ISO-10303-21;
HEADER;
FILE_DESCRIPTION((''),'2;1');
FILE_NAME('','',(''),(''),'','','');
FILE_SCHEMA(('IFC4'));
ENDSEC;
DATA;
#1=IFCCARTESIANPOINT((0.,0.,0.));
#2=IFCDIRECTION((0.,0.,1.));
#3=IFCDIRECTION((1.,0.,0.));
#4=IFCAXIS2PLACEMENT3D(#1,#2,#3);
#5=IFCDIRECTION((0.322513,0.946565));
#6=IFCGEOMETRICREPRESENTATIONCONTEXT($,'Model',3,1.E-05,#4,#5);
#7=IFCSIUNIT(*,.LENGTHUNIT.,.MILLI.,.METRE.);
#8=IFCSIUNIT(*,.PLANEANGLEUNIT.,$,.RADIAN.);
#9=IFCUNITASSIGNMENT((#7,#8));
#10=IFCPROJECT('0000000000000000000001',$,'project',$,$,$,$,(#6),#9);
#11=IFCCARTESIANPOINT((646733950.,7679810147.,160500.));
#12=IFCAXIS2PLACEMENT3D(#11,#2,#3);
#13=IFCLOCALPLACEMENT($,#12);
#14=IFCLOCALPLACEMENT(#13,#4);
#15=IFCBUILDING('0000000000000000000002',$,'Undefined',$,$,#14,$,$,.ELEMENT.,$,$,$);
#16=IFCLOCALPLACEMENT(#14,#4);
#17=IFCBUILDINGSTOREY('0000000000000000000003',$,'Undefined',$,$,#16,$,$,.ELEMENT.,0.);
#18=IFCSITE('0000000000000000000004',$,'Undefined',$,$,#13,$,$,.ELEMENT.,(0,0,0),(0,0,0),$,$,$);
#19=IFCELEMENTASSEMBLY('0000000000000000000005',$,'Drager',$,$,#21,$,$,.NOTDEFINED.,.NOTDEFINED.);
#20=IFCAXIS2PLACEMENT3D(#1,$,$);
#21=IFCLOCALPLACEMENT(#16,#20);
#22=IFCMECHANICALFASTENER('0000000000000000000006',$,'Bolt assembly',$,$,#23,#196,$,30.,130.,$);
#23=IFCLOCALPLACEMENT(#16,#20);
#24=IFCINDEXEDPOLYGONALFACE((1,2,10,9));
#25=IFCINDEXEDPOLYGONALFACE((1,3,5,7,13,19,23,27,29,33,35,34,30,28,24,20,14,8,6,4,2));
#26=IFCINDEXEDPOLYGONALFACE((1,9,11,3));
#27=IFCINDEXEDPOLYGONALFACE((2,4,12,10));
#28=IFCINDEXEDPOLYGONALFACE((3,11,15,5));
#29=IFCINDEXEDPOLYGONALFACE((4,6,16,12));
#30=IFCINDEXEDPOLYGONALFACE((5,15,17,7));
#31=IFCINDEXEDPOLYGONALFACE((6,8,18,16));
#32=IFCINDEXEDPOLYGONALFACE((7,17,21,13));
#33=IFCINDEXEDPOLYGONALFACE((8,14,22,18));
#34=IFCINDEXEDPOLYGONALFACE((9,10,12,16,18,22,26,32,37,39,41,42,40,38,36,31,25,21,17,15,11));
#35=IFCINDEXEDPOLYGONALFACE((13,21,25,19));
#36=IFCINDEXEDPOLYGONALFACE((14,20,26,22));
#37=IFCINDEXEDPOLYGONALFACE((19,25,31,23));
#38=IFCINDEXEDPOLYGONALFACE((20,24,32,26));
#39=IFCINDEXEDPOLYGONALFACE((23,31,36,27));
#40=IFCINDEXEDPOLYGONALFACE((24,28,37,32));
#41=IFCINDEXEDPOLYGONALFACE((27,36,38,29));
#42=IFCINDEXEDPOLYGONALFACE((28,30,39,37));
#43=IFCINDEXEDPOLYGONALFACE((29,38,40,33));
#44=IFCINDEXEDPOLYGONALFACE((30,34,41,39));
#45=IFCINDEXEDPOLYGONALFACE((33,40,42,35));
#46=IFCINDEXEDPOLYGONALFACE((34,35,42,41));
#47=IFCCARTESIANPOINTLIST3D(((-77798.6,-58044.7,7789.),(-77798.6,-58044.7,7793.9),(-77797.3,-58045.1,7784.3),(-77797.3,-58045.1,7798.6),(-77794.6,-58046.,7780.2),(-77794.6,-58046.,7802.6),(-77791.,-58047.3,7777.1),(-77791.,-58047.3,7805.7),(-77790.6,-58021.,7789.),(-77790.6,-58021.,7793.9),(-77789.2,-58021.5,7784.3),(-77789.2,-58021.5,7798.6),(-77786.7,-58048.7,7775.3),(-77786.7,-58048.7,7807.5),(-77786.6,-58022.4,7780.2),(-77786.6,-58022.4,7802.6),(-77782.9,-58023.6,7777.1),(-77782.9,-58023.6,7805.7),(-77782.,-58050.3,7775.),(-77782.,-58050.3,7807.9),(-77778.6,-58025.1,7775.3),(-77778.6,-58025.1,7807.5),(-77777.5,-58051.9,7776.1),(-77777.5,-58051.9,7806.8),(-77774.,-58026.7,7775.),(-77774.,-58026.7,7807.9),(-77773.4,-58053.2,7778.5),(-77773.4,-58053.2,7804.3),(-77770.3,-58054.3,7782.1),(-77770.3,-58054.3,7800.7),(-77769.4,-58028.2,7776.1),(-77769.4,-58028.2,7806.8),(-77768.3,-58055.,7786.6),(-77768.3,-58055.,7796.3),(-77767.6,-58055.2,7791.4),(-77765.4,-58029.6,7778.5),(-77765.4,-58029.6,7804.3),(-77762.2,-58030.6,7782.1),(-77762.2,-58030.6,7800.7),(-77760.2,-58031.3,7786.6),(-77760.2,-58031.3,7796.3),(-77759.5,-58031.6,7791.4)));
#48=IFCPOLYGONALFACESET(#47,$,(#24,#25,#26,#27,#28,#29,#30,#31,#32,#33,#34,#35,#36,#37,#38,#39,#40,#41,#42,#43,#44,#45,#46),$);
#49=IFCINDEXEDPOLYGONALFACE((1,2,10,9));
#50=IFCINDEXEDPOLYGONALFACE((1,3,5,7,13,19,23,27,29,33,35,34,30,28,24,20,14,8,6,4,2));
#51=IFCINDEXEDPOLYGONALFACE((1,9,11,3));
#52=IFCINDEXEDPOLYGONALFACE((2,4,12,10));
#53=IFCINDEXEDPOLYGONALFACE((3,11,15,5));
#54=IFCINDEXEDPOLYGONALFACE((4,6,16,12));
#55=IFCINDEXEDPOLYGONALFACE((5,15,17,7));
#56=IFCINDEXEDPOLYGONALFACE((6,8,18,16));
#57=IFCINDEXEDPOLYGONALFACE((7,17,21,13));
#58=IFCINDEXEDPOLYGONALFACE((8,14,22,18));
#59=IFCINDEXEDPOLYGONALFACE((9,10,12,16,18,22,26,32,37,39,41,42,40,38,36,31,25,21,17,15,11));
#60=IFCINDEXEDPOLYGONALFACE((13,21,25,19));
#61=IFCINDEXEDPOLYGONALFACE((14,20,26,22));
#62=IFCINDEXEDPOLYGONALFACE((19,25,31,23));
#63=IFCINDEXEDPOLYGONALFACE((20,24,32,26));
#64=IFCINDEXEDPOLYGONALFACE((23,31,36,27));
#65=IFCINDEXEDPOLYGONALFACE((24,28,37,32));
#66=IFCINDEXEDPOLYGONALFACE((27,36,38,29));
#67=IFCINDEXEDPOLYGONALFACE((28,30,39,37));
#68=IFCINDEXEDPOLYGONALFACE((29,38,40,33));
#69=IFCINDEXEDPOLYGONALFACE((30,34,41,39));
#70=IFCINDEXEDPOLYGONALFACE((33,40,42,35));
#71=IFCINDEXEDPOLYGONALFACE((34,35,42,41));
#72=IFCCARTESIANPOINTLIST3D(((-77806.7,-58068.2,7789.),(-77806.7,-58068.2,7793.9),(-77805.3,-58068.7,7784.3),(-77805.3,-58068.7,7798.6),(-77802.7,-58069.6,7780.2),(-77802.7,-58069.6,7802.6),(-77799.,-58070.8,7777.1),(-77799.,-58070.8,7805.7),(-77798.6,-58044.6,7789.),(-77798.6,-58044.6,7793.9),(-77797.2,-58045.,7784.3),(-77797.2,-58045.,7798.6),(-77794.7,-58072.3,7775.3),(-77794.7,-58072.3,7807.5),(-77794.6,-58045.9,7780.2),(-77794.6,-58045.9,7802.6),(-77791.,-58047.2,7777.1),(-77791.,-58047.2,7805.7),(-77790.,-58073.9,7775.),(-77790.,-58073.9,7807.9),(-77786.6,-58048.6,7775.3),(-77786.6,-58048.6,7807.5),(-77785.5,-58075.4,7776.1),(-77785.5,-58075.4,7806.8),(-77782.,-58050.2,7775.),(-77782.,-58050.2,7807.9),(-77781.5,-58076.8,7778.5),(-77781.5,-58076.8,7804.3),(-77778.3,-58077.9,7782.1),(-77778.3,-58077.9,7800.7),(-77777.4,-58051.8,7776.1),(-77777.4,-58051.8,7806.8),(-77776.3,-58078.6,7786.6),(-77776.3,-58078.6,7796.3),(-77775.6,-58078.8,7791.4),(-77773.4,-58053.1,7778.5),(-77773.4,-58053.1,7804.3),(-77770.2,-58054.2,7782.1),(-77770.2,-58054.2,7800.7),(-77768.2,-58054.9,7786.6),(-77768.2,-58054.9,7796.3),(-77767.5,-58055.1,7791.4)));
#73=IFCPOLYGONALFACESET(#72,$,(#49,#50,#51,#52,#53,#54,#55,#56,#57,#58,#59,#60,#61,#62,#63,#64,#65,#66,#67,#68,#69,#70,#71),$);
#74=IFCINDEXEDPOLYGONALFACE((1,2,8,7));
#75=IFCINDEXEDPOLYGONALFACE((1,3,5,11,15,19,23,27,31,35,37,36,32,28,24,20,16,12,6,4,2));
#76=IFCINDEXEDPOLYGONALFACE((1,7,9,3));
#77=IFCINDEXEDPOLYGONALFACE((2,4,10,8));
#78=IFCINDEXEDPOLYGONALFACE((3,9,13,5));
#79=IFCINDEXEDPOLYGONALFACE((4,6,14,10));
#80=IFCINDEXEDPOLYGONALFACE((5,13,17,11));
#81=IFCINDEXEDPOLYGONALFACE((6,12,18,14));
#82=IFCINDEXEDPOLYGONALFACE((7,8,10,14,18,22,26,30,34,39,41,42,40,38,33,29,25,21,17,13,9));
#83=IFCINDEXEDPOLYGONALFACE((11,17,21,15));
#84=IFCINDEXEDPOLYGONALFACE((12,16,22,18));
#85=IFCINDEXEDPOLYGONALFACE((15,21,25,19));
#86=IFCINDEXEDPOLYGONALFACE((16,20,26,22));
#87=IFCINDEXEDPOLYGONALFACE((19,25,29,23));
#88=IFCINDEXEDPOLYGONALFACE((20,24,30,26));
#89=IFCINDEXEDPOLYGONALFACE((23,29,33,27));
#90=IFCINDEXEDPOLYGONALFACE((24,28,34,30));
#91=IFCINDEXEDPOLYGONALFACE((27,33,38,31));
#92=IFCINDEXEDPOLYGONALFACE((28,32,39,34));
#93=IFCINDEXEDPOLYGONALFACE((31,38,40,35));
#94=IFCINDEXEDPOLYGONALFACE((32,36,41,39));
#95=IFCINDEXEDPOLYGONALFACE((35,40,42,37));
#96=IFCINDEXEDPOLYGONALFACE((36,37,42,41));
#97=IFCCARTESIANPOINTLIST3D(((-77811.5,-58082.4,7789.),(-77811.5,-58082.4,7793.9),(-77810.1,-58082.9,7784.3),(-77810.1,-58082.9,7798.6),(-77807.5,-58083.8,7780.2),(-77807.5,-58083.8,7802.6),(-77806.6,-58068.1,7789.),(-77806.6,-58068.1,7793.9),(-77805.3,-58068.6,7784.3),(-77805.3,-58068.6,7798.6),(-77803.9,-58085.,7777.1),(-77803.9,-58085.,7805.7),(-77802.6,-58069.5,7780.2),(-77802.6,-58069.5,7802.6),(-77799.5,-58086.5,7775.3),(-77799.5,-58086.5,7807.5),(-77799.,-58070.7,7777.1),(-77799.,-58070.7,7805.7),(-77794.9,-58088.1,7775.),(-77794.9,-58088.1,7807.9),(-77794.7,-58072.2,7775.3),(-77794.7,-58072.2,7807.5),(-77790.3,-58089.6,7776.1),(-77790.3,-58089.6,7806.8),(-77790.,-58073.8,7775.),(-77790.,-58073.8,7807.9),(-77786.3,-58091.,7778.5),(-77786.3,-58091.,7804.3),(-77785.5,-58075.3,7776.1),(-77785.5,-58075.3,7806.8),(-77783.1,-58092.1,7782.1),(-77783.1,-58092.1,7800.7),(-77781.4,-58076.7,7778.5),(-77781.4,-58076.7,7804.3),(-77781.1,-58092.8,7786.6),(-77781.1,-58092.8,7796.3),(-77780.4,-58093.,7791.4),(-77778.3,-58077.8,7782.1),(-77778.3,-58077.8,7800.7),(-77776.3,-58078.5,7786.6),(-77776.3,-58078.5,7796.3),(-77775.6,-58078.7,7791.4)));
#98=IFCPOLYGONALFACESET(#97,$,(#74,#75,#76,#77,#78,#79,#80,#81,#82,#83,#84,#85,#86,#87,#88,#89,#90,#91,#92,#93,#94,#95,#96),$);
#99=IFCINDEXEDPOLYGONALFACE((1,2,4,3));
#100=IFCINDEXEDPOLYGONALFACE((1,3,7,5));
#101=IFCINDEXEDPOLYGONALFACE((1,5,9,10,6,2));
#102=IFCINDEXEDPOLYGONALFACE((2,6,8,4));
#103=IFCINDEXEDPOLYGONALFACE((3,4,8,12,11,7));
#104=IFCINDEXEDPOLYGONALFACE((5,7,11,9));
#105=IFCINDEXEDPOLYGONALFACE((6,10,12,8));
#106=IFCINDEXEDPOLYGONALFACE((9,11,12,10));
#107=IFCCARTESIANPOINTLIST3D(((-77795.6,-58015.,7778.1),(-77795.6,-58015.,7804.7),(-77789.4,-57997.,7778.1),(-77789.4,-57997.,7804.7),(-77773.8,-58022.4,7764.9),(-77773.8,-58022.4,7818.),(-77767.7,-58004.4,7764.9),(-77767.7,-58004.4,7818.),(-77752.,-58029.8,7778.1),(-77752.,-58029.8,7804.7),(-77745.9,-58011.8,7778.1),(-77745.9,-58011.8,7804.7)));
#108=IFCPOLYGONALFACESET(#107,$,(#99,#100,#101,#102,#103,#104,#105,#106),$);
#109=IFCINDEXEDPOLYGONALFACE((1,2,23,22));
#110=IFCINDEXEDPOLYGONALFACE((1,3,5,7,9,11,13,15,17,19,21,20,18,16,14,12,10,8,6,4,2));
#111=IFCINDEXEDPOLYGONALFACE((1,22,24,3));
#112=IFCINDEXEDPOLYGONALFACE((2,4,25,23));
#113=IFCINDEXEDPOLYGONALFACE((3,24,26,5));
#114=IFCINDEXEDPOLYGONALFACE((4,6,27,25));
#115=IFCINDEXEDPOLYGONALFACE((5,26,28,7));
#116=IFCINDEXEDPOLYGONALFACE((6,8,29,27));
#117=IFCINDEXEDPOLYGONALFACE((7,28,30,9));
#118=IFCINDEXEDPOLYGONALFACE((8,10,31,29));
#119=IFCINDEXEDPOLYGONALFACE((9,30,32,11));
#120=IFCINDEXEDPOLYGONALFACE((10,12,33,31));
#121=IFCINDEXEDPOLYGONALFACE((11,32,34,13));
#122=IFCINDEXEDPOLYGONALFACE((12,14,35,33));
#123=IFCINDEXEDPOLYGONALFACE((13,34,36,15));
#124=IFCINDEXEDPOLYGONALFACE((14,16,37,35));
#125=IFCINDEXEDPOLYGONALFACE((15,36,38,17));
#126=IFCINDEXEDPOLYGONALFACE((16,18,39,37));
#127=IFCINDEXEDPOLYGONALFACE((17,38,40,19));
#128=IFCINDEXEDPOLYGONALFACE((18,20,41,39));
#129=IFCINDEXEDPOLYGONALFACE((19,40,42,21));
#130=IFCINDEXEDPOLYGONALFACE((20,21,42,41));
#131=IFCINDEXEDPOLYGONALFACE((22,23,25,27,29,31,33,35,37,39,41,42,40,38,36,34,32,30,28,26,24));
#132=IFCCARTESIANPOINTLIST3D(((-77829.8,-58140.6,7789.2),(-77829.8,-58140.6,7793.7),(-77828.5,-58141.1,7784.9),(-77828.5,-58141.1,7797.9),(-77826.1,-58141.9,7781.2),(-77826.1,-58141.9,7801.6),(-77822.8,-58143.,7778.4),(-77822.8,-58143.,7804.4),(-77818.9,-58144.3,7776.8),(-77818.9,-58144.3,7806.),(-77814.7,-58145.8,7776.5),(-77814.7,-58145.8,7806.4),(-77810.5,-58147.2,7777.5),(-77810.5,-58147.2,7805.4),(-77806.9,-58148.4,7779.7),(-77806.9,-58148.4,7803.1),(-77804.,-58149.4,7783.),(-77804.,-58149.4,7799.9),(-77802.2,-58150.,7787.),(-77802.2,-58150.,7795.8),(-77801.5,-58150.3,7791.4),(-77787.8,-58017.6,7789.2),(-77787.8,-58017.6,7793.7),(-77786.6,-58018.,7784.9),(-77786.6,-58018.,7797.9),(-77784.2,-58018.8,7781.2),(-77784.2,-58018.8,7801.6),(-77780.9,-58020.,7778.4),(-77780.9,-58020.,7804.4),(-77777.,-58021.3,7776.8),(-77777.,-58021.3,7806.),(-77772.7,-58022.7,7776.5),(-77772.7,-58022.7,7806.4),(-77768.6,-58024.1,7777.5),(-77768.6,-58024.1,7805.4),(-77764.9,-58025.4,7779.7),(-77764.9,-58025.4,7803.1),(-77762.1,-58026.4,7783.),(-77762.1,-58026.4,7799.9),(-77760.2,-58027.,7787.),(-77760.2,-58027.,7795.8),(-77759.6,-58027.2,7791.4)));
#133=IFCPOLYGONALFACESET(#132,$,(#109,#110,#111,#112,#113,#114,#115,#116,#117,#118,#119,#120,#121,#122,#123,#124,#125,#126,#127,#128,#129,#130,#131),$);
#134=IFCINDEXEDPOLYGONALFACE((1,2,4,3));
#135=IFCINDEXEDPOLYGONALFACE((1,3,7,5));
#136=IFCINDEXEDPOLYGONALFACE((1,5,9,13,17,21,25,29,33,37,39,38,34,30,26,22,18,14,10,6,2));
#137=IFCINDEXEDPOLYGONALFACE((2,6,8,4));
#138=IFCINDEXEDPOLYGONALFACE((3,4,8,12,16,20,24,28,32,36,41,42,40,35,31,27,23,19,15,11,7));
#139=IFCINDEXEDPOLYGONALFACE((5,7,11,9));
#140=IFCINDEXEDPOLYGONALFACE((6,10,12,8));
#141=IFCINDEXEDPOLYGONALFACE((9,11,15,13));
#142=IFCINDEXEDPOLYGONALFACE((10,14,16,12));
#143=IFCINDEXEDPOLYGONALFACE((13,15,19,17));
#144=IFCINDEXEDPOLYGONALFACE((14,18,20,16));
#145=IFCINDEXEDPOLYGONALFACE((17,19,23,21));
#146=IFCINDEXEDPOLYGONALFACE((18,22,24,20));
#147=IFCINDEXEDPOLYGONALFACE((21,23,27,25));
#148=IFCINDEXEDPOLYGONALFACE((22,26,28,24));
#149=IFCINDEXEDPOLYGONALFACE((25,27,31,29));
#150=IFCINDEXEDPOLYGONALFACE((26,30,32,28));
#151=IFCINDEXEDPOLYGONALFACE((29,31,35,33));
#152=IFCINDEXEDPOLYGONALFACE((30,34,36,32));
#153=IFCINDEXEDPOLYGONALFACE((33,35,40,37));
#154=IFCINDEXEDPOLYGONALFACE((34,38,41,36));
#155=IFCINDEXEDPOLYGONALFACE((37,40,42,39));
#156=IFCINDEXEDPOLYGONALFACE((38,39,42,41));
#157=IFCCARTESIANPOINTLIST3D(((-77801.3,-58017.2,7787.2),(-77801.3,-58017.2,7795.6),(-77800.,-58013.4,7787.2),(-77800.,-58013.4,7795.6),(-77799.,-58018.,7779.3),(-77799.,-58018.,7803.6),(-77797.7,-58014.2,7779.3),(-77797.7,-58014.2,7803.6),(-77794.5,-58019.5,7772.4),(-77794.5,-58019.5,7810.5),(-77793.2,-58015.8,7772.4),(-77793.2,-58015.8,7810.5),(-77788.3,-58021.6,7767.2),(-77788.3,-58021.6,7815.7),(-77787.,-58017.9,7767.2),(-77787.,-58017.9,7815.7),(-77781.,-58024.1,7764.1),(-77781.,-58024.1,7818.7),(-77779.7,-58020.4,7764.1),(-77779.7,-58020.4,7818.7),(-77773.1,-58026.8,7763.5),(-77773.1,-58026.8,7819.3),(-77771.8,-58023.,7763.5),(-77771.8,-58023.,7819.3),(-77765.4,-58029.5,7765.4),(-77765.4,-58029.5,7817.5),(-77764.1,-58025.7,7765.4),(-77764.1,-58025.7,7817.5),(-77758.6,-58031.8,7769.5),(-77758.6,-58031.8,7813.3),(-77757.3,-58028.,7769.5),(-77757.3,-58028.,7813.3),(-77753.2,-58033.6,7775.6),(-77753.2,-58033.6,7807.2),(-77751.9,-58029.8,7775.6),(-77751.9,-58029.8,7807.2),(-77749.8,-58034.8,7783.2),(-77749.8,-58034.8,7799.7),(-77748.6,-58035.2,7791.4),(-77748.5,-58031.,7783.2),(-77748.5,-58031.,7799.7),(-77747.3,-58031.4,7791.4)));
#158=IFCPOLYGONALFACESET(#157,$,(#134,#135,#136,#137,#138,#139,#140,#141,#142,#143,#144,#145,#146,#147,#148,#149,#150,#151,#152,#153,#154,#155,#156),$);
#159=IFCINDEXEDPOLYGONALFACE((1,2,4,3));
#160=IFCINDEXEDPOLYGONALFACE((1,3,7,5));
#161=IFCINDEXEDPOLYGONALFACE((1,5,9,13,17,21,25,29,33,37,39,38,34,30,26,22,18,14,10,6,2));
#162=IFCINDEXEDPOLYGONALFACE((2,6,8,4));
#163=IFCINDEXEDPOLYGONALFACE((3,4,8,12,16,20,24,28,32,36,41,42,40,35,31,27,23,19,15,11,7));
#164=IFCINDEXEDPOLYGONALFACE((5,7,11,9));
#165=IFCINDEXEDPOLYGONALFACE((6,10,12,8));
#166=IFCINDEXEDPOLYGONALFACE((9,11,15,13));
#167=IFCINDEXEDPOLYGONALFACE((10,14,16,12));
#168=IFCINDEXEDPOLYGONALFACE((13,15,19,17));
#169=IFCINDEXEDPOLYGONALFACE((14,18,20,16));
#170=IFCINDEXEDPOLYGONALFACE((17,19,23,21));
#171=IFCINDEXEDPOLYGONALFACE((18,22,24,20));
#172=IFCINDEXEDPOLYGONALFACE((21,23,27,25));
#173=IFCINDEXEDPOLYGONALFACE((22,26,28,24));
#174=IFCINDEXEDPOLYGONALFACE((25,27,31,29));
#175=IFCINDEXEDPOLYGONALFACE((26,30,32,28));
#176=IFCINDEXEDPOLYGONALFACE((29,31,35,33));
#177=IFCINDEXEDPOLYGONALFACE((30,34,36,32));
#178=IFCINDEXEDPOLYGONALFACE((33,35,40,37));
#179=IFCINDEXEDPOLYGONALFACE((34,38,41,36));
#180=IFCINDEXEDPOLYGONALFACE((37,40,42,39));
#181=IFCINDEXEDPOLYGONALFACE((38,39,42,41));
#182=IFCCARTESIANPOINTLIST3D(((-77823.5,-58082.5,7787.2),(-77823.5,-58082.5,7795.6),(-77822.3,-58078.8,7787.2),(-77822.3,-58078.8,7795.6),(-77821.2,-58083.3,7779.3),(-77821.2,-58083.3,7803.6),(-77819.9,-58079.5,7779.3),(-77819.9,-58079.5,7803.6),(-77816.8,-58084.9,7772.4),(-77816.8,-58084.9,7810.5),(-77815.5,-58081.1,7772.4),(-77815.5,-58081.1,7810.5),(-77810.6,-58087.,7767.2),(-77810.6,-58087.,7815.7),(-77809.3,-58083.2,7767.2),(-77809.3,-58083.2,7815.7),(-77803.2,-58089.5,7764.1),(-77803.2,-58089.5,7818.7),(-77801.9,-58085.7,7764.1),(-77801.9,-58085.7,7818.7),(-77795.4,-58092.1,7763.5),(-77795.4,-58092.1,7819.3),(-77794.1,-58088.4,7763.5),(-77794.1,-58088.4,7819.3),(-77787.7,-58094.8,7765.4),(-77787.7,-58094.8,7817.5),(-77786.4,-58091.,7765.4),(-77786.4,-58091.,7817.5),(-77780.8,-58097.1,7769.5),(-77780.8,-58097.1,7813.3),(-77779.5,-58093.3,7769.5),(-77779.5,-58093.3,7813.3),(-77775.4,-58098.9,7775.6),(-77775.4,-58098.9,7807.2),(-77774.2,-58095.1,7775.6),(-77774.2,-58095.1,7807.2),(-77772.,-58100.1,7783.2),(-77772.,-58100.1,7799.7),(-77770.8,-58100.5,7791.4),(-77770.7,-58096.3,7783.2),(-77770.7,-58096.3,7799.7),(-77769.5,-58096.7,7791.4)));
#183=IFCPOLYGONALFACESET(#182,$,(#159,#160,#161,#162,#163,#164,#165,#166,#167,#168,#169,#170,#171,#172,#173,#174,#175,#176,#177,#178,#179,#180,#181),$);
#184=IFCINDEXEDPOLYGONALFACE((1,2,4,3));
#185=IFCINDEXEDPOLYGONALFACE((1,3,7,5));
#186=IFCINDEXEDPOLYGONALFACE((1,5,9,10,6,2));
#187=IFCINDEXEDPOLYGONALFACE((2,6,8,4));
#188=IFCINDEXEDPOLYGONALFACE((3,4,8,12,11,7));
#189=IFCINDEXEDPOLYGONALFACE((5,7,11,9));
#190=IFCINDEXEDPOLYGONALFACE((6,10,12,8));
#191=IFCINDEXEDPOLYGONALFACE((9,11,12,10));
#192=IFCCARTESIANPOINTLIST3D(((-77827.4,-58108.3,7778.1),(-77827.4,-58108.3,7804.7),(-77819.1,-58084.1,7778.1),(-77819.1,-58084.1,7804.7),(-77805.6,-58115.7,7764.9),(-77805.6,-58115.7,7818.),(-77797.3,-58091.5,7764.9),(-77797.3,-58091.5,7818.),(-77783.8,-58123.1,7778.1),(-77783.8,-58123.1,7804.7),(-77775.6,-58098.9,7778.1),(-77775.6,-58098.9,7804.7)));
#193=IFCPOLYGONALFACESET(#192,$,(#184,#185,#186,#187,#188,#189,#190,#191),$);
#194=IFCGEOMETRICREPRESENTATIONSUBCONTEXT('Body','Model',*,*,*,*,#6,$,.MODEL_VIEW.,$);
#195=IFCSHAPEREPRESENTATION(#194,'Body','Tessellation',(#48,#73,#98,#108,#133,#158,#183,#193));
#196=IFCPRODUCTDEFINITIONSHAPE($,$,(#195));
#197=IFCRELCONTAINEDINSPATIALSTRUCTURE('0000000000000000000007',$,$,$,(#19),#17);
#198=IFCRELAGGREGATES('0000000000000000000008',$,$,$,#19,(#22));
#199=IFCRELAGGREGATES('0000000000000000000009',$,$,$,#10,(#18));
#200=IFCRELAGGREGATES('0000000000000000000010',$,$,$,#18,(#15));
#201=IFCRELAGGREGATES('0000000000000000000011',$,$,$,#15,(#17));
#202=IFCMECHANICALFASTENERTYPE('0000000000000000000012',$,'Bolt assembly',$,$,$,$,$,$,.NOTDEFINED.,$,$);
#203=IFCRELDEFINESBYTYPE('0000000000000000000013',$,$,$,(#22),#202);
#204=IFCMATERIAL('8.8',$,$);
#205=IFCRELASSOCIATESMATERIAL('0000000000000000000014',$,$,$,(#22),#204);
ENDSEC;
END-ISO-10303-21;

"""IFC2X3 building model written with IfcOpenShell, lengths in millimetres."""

from ifc_helpers import new_model, si_unit, direction, frame, origin_with_axes, origin_2d_with_axis, place, context, subcontext, project, spatial, polyline, circle, outline, extrude, source, transform, mapped, material, type_object, element, aggregate, save


model = new_model("IFC2X3")

# Units and contexts
model_context = context("Model", 3, precision=1e-05, world=origin_with_axes(), true_north=direction((0.322513, 0.946565)))
body_context = subcontext(model_context, "Body", "Model", "MODEL_VIEW")
ifc_project = project(units=[si_unit("LENGTHUNIT", "METRE", prefix="MILLI"), si_unit("PLANEANGLEUNIT", "RADIAN")], contexts=[model_context])

# Site, building, storey
site_placement = place(None, frame((646733950.0, 7679810147.0, 160500.0), z_axis=(0.0, 0.0, 1.0), x_axis=(1.0, 0.0, 0.0)))
site = spatial("IfcSite", under=ifc_project, at=site_placement, Name="Undefined", CompositionType="ELEMENT", RefLatitude=(0, 0, 0), RefLongitude=(0, 0, 0))
building_placement = place(site_placement, origin_with_axes())
building = spatial("IfcBuilding", under=site, at=building_placement, Name="Undefined", CompositionType="ELEMENT")
storey_placement = place(building_placement, origin_with_axes())
storey = spatial("IfcBuildingStorey", under=building, at=storey_placement, Name="Undefined", CompositionType="ELEMENT", Elevation=0.0)

# Element assembly
assembly_1_placement = place(storey_placement, origin_with_axes())
assembly_1 = element("IfcElementAssembly", 1, at=assembly_1_placement, inside=storey, Name="Drager", AssemblyPlace="NOTDEFINED", PredefinedType="NOTDEFINED")

# Mechanical fastener
ifc_material_1 = material(Name="8.8")
mechanical_fastener_type = type_object("IfcMechanicalFastenerType", Name="Bolt assembly")
shared_shape_1 = source(origin_with_axes(), body_context, "Body", "SweptSolid", [
    extrude(circle(Radius=16.5, at=origin_2d_with_axis()), frame((0.0, -57.4, 0.0), z_axis=(0.0, 1.0, 0.0), x_axis=(1.0, 0.0, 0.0)), (0.0, 0.0, 1.0), 25.0),
    extrude(circle(Radius=16.5, at=origin_2d_with_axis()), frame((0.0, -32.5, 0.0), z_axis=(0.0, 1.0, 0.0), x_axis=(1.0, 0.0, 0.0)), (0.0, 0.0, 1.0), 25.0),
    extrude(circle(Radius=16.5, at=origin_2d_with_axis()), frame((0.0, -7.6, 0.0), z_axis=(0.0, 1.0, 0.0), x_axis=(1.0, 0.0, 0.0)), (0.0, 0.0, 1.0), 15.1),
    extrude(outline(polyline([(23.0, -13.3), (23.0, 13.3), (0.0, 26.6), (-23.0, 13.3), (-23.0, -13.3), (0.0, -26.6), (23.0, -13.3)])), frame((0.0, -80.5, 0.0), z_axis=(0.0, 1.0, 0.0), x_axis=(1.0, 0.0, 0.0)), (0.0, 0.0, 1.0), 19.0),
    extrude(circle(Radius=15.0, at=origin_2d_with_axis()), frame((0.0, -61.5, 0.0), z_axis=(0.0, 1.0, 0.0), x_axis=(1.0, 0.0, 0.0)), (0.0, 0.0, 1.0), 130.0),
    extrude(circle(Radius=28.0, at=origin_2d_with_axis()), frame((0.0, -61.5, 0.0), z_axis=(0.0, 1.0, 0.0), x_axis=(1.0, 0.0, 0.0)), (0.0, 0.0, 1.0), 4.0),
    extrude(circle(Radius=28.0, at=origin_2d_with_axis()), frame((0.0, 7.5, 0.0), z_axis=(0.0, 1.0, 0.0), x_axis=(1.0, 0.0, 0.0)), (0.0, 0.0, 1.0), 4.0),
    extrude(outline(polyline([(23.0, -13.3), (23.0, 13.3), (0.0, 26.6), (-23.0, 13.3), (-23.0, -13.3), (0.0, -26.6), (23.0, -13.3)])), frame((0.0, 11.5, 0.0), z_axis=(0.0, 1.0, 0.0), x_axis=(1.0, 0.0, 0.0)), (0.0, 0.0, 1.0), 25.6),
])
mechanical_fastener_1_placement = place(assembly_1_placement, frame((-77793.6, -58080.6, 7791.4), z_axis=(0.0, 0.0, -1.0), x_axis=(0.946565, -0.322513, 0.0)))
mechanical_fastener_1 = element("IfcMechanicalFastener", 2, at=mechanical_fastener_1_placement, type_object=mechanical_fastener_type, material=ifc_material_1, Name="Bolt assembly", NominalDiameter=30.0, NominalLength=130.0, context=body_context, shape_type="MappedRepresentation", body=[
    mapped(shared_shape_1, transform((0.0, 0.0, 0.0))),
])
aggregate(assembly_1, [mechanical_fastener_1])

save(model, "model.ifc")
